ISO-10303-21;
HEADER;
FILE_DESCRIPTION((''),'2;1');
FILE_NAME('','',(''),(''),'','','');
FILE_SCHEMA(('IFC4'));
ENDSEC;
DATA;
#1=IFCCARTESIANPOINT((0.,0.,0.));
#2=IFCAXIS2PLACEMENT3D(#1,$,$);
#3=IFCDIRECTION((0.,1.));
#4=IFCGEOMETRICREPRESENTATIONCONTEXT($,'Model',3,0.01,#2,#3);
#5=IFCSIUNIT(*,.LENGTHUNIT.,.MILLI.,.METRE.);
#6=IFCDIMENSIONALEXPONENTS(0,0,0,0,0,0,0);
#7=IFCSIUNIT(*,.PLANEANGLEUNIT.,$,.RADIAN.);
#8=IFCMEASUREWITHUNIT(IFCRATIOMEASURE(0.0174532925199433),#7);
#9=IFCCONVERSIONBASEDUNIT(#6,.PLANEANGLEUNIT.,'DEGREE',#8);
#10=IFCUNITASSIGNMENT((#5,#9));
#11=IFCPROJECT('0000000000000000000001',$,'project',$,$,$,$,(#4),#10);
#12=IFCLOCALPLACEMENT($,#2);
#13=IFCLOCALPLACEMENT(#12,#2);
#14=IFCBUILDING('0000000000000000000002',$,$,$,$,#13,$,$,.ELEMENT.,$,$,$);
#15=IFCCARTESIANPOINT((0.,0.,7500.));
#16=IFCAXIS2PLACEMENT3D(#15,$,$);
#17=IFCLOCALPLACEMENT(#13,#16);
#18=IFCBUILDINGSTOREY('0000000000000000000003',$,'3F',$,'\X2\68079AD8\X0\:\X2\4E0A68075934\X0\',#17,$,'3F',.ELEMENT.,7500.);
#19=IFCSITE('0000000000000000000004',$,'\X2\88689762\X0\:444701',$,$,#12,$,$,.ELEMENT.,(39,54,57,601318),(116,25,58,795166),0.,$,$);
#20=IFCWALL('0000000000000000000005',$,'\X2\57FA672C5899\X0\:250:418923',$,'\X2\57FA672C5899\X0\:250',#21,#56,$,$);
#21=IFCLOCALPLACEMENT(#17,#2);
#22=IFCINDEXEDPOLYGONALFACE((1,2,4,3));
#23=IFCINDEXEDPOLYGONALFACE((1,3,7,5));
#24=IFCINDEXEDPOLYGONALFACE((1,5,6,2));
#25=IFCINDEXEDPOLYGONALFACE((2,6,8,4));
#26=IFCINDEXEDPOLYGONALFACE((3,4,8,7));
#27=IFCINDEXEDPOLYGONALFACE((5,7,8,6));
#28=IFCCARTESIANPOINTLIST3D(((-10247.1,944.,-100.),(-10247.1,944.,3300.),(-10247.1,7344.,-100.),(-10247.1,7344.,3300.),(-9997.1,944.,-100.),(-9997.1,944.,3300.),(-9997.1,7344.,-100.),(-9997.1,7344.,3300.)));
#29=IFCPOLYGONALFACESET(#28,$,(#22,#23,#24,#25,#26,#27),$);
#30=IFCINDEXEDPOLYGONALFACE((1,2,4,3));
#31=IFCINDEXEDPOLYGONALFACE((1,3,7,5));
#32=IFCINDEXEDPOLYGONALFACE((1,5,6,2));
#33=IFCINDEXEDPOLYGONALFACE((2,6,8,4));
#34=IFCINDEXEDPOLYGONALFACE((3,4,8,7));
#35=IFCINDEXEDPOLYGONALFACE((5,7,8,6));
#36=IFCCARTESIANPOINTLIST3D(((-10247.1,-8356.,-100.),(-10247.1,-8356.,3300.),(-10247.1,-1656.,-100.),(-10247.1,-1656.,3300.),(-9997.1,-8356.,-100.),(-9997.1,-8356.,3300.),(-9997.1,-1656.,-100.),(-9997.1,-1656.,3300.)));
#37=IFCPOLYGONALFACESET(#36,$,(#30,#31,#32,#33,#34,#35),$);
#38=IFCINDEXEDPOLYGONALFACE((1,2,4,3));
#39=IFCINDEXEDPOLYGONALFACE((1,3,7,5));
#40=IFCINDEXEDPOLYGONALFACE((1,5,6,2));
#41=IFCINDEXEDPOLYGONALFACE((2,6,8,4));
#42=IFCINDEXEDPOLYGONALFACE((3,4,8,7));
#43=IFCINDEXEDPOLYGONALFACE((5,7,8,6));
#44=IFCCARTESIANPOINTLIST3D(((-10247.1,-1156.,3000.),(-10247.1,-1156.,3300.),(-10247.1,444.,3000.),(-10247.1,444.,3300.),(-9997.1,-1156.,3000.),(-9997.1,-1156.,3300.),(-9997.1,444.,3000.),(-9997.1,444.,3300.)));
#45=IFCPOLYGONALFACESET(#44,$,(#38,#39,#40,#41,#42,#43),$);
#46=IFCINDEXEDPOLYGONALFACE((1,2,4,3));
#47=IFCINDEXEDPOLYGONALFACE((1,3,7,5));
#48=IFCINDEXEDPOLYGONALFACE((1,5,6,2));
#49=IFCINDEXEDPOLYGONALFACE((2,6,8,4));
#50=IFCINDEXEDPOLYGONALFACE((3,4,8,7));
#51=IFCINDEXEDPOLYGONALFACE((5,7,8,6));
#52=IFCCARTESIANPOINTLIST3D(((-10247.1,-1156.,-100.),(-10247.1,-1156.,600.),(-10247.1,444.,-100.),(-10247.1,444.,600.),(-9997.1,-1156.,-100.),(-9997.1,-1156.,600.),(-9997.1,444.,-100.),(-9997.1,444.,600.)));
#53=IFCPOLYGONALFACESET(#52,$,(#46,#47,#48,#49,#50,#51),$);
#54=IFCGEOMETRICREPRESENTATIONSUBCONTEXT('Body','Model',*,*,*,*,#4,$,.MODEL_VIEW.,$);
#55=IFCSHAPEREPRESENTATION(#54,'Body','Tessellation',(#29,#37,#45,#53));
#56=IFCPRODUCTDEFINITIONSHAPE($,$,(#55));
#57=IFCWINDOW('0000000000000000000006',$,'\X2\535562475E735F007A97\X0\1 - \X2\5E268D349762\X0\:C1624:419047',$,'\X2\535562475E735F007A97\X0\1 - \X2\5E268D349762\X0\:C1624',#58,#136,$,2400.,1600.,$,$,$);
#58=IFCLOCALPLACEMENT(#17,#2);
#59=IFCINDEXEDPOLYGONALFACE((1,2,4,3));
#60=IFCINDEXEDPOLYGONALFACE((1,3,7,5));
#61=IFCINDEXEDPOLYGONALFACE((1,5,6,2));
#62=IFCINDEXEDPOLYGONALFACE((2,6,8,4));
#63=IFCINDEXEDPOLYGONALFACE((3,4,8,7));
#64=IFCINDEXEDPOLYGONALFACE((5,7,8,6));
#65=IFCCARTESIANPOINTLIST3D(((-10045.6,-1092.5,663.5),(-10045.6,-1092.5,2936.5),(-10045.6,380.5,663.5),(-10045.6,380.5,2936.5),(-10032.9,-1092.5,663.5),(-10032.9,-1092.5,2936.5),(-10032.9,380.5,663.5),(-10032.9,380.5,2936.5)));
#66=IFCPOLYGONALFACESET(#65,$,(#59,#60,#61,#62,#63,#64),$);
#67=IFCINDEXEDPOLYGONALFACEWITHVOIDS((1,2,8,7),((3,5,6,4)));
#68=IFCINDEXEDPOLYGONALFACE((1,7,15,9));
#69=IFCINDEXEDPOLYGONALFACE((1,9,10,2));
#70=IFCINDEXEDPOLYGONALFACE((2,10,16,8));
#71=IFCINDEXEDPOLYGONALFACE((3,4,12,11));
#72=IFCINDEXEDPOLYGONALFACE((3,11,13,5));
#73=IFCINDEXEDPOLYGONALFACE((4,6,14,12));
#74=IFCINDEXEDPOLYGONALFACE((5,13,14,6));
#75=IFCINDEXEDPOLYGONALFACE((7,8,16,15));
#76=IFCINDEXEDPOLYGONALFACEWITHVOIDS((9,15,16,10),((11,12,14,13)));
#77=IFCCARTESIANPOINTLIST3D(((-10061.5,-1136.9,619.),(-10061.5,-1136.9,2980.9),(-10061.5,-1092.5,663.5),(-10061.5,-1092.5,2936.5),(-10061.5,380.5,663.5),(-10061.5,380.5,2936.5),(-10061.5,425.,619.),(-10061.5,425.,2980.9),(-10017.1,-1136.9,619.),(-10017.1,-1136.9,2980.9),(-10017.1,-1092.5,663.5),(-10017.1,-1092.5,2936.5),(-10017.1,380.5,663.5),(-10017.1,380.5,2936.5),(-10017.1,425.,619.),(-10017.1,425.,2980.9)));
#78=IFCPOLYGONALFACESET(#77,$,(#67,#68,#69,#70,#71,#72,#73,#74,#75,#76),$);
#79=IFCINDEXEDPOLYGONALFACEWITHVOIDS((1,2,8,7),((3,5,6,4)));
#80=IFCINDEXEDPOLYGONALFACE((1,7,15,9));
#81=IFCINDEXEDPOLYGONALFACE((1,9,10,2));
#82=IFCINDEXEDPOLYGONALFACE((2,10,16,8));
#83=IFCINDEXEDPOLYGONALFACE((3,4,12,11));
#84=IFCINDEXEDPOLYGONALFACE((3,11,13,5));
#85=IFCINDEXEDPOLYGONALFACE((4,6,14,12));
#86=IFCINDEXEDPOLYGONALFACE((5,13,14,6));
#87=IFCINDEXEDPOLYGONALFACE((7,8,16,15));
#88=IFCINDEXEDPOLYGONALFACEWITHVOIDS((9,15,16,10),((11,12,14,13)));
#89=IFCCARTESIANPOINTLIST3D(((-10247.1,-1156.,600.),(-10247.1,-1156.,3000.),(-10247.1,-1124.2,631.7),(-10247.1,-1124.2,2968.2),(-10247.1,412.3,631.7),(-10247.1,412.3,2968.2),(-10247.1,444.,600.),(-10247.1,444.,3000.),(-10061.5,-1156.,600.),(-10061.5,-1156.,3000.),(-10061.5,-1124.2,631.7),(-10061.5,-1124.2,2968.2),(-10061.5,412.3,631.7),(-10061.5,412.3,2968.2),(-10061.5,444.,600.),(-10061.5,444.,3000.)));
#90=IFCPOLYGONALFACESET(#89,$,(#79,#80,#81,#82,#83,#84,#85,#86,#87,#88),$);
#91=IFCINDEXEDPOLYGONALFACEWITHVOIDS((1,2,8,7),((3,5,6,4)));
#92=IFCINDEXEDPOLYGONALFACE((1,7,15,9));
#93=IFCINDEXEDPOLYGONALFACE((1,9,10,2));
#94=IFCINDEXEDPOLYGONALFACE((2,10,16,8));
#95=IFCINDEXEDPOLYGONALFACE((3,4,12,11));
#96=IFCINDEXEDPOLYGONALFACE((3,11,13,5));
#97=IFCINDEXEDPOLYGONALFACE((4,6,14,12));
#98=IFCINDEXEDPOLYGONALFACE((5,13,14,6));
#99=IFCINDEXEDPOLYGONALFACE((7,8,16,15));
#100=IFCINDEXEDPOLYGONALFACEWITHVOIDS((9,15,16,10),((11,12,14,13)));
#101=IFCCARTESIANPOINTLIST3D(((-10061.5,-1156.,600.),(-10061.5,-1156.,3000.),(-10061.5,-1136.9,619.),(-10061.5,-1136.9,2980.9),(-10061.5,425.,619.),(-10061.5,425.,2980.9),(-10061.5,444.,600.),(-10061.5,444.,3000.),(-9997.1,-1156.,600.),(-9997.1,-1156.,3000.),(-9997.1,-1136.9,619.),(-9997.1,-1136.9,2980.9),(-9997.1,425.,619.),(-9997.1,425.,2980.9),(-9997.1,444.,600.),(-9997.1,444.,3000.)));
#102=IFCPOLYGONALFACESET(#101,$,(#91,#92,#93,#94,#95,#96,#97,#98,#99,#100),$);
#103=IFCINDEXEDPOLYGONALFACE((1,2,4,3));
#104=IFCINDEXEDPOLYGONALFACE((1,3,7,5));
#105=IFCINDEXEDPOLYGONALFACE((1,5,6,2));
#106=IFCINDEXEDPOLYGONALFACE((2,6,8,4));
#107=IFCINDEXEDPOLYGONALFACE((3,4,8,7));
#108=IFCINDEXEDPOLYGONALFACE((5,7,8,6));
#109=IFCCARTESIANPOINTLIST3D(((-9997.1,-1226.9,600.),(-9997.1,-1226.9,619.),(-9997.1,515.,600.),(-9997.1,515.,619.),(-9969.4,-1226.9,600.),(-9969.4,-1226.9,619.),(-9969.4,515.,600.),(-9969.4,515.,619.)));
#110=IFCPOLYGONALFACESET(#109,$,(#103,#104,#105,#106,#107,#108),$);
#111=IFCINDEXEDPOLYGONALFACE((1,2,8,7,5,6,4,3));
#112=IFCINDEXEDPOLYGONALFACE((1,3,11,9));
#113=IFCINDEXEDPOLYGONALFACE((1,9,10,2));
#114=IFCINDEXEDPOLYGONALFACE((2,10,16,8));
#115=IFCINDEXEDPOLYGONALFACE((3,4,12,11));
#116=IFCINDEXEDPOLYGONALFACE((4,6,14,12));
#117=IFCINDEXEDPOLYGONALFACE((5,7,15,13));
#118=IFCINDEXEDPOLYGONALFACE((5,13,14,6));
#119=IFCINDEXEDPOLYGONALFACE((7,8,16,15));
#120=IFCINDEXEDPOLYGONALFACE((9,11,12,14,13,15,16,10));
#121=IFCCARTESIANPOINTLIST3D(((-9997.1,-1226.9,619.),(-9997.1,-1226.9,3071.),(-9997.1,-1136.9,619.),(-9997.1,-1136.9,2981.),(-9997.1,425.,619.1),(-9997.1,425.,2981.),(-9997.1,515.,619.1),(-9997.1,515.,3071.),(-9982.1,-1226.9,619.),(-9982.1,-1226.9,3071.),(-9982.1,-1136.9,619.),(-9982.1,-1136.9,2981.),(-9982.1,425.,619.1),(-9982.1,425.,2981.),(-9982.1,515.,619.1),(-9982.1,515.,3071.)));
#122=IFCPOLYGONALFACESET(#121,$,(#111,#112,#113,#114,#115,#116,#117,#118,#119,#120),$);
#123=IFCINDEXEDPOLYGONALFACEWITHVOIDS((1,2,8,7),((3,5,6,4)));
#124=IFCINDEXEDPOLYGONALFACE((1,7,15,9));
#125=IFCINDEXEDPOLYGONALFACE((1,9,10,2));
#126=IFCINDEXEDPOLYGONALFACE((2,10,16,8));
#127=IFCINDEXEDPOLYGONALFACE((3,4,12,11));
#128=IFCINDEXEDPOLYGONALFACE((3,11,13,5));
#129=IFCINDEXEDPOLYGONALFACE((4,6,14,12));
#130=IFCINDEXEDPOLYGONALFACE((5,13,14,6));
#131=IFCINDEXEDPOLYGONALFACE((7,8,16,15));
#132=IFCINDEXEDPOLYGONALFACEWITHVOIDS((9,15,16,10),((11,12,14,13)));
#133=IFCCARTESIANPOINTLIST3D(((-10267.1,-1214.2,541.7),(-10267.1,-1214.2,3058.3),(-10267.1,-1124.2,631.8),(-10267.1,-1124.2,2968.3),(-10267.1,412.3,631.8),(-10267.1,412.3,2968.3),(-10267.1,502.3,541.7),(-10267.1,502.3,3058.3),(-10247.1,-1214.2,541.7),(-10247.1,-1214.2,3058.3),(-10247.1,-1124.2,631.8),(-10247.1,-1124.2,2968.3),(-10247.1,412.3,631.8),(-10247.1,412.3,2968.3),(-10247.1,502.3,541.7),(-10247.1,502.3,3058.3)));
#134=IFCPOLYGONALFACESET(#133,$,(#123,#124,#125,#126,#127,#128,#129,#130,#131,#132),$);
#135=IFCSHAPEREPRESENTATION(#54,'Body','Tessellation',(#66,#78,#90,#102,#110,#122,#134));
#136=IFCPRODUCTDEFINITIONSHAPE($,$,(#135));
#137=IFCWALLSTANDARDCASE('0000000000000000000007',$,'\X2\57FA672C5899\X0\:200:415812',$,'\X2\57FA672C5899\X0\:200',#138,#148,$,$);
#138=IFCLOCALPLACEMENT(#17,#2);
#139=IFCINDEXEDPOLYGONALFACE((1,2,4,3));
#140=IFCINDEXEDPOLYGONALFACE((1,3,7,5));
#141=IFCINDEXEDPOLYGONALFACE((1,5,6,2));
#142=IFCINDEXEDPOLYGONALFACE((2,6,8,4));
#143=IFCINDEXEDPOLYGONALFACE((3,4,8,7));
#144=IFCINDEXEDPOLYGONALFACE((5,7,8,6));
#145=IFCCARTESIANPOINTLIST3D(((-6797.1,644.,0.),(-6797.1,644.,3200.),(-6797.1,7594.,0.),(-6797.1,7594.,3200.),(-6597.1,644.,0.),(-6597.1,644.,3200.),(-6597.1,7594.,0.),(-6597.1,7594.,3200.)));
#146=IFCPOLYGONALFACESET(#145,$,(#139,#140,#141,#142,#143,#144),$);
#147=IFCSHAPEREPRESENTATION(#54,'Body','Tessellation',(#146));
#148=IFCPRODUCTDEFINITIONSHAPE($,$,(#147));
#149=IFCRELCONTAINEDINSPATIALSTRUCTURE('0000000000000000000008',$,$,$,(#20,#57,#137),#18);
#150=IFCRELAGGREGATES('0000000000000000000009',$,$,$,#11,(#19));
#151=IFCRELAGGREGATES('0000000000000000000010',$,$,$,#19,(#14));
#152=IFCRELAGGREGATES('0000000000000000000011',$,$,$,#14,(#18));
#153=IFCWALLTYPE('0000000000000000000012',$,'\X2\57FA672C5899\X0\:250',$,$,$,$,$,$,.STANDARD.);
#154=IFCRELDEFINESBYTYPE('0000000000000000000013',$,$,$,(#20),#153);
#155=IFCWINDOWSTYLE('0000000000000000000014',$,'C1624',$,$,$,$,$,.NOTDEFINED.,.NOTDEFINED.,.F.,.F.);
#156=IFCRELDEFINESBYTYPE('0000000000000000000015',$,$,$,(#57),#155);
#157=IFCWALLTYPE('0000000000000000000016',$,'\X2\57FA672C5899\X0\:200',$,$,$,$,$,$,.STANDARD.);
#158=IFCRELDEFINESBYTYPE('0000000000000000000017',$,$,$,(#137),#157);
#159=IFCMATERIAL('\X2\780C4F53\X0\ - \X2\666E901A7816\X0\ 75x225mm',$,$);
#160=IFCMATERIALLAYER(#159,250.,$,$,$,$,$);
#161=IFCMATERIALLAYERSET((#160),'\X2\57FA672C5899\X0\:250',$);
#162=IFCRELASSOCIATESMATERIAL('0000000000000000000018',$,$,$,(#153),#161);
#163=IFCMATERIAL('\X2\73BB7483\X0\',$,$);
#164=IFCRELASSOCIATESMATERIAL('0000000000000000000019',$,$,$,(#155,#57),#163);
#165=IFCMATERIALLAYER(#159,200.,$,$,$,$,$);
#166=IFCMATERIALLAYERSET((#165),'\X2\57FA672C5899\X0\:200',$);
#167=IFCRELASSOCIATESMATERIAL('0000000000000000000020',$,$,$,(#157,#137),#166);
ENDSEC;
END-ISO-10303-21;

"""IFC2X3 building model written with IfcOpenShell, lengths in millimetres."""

from ifc_helpers import new_model, entity, si_unit, converted_unit, direction, frame, frame_2d, origin, origin_2d_with_axis, place, context, subcontext, project, spatial, polyline, rectangle, outline, extrude, source, transform, mapped, material, layer, layer_set, layer_usage, type_object, type_shapes, element, fill, save


model = new_model("IFC2X3")

# Units and contexts
model_context = context("Model", 3, precision=0.01, world=origin(), true_north=direction((0.0, 1.0)))
body_context = subcontext(model_context, "Body", "Model", "MODEL_VIEW")
ifc_project = project(units=[si_unit("LENGTHUNIT", "METRE", prefix="MILLI"), converted_unit("PLANEANGLEUNIT", "DEGREE", entity("IfcRatioMeasure", 0.0174532925199433), si_unit("PLANEANGLEUNIT", "RADIAN"), dimensions=[0, 0, 0, 0, 0, 0, 0])], contexts=[model_context])

# Site, building, storey
site_placement = place(None, origin())
site = spatial("IfcSite", under=ifc_project, at=site_placement, Name="表面:444701", CompositionType="ELEMENT", RefLatitude=(39, 54, 57, 601318), RefLongitude=(116, 25, 58, 795166), RefElevation=0.0)
building_placement = place(site_placement, origin())
building = spatial("IfcBuilding", under=site, at=building_placement, CompositionType="ELEMENT")
storey_placement = place(building_placement, frame((0.0, 0.0, 7500.0)))
storey = spatial("IfcBuildingStorey", under=building, at=storey_placement, Name="3F", ObjectType="标高:上标头", LongName="3F", CompositionType="ELEMENT", Elevation=7500.0)

# Shared definitions
ifc_material_1 = material(Name="砌体 - 普通砖 75x225mm")
ifc_layer_1 = layer(ifc_material_1, 250.0)
ifc_layer_set_1 = layer_set([ifc_layer_1], Name="基本墙:250")
wall_type_1 = type_object("IfcWallType", Name="基本墙:250", PredefinedType="STANDARD", material=ifc_layer_set_1)
ifc_material_2 = material(Name="玻璃")
window_style_1 = type_object("IfcWindowStyle", Name="C1624", ConstructionType="NOTDEFINED", OperationType="NOTDEFINED", ParameterTakesPrecedence=False, Sizeable=False, material=ifc_material_2)
shared_shape_1 = source(origin(), body_context, "Body", "SweptSolid", [
    extrude(rectangle(XDim=12.7, YDim=1473.0, at=origin_2d_with_axis()), frame((800.0, 207.8, 63.5), z_axis=(0.0, 0.0, 1.0), x_axis=(0.0, 1.0, 0.0)), (0.0, 0.0, 1.0), 2273.0),
    extrude(outline(polyline([(-780.9, -1181.0), (780.9, -1181.0), (780.9, 1181.0), (-780.9, 1181.0), (-780.9, -1181.0)]), holes=[polyline([(-736.5, -1136.5), (-736.5, 1136.5), (736.5, 1136.5), (736.5, -1136.5), (-736.5, -1136.5)])]), frame((800.0, 185.6, 1200.0), z_axis=(0.0, 1.0, 0.0), x_axis=(1.0, 0.0, 0.0)), (0.0, 0.0, 1.0), 44.5),
    extrude(outline(polyline([(-800.0, -1200.0), (800.0, -1200.0), (800.0, 1200.0), (-800.0, 1200.0), (-800.0, -1200.0)]), holes=[polyline([(-768.2, -1168.2), (-768.2, 1168.2), (768.2, 1168.2), (768.2, -1168.2), (-768.2, -1168.2)])]), frame((800.0, 0.0, 1200.0), z_axis=(0.0, 1.0, 0.0), x_axis=(1.0, 0.0, 0.0)), (0.0, 0.0, 1.0), 185.6),
    extrude(outline(polyline([(-1200.0, -800.0), (1200.0, -800.0), (1200.0, 800.0), (-1200.0, 800.0), (-1200.0, -800.0)]), holes=[polyline([(-1181.0, -780.9), (-1181.0, 781.0), (1181.0, 781.0), (1181.0, -780.9), (-1181.0, -780.9)])]), frame((800.0, 185.6, 1200.0), z_axis=(0.0, 1.0, 0.0), x_axis=(0.0, 0.0, -1.0)), (0.0, 0.0, 1.0), 64.5),
    extrude(rectangle(XDim=27.7, YDim=1741.9, at=frame_2d((0.0, 0.0), x_axis=(1.0, 0.0))), frame((800.0, 263.9, 0.0), z_axis=(0.0, 0.0, 1.0), x_axis=(0.0, -1.0, 0.0)), (0.0, 0.0, 1.0), 19.0),
    extrude(outline(polyline([(-1158.5, 780.9), (1203.5, 780.9), (1203.5, 870.9), (-1248.5, 870.9), (-1248.5, -870.9), (1203.5, -870.9), (1203.5, -780.9), (-1158.5, -780.9), (-1158.5, 780.9)])), frame((800.0, 250.0, 1222.5), z_axis=(0.0, 1.0, 0.0), x_axis=(0.0, 0.0, -1.0)), (0.0, 0.0, 1.0), 15.0),
    extrude(outline(polyline([(-1258.3, -858.2), (1258.3, -858.2), (1258.3, 858.2), (-1258.3, 858.2), (-1258.3, -858.2)]), holes=[polyline([(-1168.3, -768.2), (-1168.3, 768.3), (1168.2, 768.3), (1168.2, -768.2), (-1168.3, -768.2)])]), frame((800.0, -20.0, 1200.0), z_axis=(0.0, 1.0, 0.0), x_axis=(0.0, 0.0, -1.0)), (0.0, 0.0, 1.0), 20.0),
])
type_shapes(window_style_1, [shared_shape_1])

# Wall, opening, window
wall_1_placement = place(storey_placement, frame((-10122.1, 7344.0, -100.0), z_axis=(0.0, 0.0, 1.0), x_axis=(0.0, -1.0, 0.0)))
wall_1 = element("IfcWall", 1, at=wall_1_placement, inside=storey, type_object=wall_type_1, Name="基本墙:250:418923", ObjectType="基本墙:250", context=body_context, shape_type="SweptSolid", body=[
    extrude(rectangle(XDim=6400.0, YDim=250.0, at=frame_2d((0.0, 0.0), x_axis=(1.0, 0.0))), frame((3200.0, 0.0, 0.0)), (0.0, 0.0, 1.0), 3400.0),
    extrude(rectangle(XDim=6700.0, YDim=250.0, at=frame_2d((0.0, 0.0), x_axis=(1.0, 0.0))), frame((12350.0, 0.0, 0.0)), (0.0, 0.0, 1.0), 3400.0),
    extrude(rectangle(XDim=250.0, YDim=1600.0, at=frame_2d((0.0, 0.0), x_axis=(1.0, 0.0))), frame((7700.0, 0.0, 3100.0), z_axis=(0.0, 0.0, 1.0), x_axis=(0.0, 1.0, 0.0)), (0.0, 0.0, 1.0), 300.0),
    extrude(rectangle(XDim=1600.0, YDim=250.0, at=frame_2d((0.0, 0.0), x_axis=(1.0, 0.0))), frame((7700.0, 0.0, 0.0)), (0.0, 0.0, 1.0), 700.0),
])
opening_1_placement = place(wall_1_placement, frame((6900.0, -125.0, 700.0)))
opening_1 = element("IfcOpeningElement", 2, at=opening_1_placement, cuts=wall_1, ObjectType="Opening", context=body_context, shape_type="SweptSolid", body=[
    extrude(rectangle(XDim=2400.0, YDim=1600.0, at=frame_2d((1200.0, 800.0), x_axis=(-1.0, 0.0))), frame((0.0, 0.0, 0.0), z_axis=(0.0, 1.0, 0.0), x_axis=(0.0, 0.0, 1.0)), (0.0, 0.0, 1.0), 250.0),
])
window_1_placement = place(opening_1_placement, origin())
window_1 = element("IfcWindow", 3, at=window_1_placement, inside=storey, type_object=window_style_1, material=ifc_material_2, Name="单扇平开窗1 - 带贴面:C1624:419047", ObjectType="单扇平开窗1 - 带贴面:C1624", OverallHeight=2400.0, OverallWidth=1600.0, context=body_context, shape_type="MappedRepresentation", body=[
    mapped(shared_shape_1, transform((0.0, 0.0, 0.0), scale=1.0)),
])
fill(opening_1, window_1)

# Wall
ifc_layer_2 = layer(ifc_material_1, 200.0)
ifc_layer_set_2 = layer_set([ifc_layer_2], Name="基本墙:200")
ifc_layer_usage_1 = layer_usage(ifc_layer_set_2, "AXIS2", "NEGATIVE", 100.0)
wall_type_2 = type_object("IfcWallType", Name="基本墙:200", PredefinedType="STANDARD", material=ifc_layer_set_2)
wall_2_placement = place(storey_placement, frame((-6697.1, 7594.0, 0.0), z_axis=(0.0, 0.0, 1.0), x_axis=(0.0, -1.0, 0.0)))
element("IfcWallStandardCase", 4, at=wall_2_placement, inside=storey, type_object=wall_type_2, material=ifc_layer_usage_1, Name="基本墙:200:415812", ObjectType="基本墙:200", context=body_context, shape_type="SweptSolid", body=[
    extrude(rectangle(XDim=6950.0, YDim=200.0, at=frame_2d((3475.0, 0.0), x_axis=(-1.0, 0.0))), origin(), (0.0, 0.0, 1.0), 3200.0),
])

save(model, "model.ifc")
